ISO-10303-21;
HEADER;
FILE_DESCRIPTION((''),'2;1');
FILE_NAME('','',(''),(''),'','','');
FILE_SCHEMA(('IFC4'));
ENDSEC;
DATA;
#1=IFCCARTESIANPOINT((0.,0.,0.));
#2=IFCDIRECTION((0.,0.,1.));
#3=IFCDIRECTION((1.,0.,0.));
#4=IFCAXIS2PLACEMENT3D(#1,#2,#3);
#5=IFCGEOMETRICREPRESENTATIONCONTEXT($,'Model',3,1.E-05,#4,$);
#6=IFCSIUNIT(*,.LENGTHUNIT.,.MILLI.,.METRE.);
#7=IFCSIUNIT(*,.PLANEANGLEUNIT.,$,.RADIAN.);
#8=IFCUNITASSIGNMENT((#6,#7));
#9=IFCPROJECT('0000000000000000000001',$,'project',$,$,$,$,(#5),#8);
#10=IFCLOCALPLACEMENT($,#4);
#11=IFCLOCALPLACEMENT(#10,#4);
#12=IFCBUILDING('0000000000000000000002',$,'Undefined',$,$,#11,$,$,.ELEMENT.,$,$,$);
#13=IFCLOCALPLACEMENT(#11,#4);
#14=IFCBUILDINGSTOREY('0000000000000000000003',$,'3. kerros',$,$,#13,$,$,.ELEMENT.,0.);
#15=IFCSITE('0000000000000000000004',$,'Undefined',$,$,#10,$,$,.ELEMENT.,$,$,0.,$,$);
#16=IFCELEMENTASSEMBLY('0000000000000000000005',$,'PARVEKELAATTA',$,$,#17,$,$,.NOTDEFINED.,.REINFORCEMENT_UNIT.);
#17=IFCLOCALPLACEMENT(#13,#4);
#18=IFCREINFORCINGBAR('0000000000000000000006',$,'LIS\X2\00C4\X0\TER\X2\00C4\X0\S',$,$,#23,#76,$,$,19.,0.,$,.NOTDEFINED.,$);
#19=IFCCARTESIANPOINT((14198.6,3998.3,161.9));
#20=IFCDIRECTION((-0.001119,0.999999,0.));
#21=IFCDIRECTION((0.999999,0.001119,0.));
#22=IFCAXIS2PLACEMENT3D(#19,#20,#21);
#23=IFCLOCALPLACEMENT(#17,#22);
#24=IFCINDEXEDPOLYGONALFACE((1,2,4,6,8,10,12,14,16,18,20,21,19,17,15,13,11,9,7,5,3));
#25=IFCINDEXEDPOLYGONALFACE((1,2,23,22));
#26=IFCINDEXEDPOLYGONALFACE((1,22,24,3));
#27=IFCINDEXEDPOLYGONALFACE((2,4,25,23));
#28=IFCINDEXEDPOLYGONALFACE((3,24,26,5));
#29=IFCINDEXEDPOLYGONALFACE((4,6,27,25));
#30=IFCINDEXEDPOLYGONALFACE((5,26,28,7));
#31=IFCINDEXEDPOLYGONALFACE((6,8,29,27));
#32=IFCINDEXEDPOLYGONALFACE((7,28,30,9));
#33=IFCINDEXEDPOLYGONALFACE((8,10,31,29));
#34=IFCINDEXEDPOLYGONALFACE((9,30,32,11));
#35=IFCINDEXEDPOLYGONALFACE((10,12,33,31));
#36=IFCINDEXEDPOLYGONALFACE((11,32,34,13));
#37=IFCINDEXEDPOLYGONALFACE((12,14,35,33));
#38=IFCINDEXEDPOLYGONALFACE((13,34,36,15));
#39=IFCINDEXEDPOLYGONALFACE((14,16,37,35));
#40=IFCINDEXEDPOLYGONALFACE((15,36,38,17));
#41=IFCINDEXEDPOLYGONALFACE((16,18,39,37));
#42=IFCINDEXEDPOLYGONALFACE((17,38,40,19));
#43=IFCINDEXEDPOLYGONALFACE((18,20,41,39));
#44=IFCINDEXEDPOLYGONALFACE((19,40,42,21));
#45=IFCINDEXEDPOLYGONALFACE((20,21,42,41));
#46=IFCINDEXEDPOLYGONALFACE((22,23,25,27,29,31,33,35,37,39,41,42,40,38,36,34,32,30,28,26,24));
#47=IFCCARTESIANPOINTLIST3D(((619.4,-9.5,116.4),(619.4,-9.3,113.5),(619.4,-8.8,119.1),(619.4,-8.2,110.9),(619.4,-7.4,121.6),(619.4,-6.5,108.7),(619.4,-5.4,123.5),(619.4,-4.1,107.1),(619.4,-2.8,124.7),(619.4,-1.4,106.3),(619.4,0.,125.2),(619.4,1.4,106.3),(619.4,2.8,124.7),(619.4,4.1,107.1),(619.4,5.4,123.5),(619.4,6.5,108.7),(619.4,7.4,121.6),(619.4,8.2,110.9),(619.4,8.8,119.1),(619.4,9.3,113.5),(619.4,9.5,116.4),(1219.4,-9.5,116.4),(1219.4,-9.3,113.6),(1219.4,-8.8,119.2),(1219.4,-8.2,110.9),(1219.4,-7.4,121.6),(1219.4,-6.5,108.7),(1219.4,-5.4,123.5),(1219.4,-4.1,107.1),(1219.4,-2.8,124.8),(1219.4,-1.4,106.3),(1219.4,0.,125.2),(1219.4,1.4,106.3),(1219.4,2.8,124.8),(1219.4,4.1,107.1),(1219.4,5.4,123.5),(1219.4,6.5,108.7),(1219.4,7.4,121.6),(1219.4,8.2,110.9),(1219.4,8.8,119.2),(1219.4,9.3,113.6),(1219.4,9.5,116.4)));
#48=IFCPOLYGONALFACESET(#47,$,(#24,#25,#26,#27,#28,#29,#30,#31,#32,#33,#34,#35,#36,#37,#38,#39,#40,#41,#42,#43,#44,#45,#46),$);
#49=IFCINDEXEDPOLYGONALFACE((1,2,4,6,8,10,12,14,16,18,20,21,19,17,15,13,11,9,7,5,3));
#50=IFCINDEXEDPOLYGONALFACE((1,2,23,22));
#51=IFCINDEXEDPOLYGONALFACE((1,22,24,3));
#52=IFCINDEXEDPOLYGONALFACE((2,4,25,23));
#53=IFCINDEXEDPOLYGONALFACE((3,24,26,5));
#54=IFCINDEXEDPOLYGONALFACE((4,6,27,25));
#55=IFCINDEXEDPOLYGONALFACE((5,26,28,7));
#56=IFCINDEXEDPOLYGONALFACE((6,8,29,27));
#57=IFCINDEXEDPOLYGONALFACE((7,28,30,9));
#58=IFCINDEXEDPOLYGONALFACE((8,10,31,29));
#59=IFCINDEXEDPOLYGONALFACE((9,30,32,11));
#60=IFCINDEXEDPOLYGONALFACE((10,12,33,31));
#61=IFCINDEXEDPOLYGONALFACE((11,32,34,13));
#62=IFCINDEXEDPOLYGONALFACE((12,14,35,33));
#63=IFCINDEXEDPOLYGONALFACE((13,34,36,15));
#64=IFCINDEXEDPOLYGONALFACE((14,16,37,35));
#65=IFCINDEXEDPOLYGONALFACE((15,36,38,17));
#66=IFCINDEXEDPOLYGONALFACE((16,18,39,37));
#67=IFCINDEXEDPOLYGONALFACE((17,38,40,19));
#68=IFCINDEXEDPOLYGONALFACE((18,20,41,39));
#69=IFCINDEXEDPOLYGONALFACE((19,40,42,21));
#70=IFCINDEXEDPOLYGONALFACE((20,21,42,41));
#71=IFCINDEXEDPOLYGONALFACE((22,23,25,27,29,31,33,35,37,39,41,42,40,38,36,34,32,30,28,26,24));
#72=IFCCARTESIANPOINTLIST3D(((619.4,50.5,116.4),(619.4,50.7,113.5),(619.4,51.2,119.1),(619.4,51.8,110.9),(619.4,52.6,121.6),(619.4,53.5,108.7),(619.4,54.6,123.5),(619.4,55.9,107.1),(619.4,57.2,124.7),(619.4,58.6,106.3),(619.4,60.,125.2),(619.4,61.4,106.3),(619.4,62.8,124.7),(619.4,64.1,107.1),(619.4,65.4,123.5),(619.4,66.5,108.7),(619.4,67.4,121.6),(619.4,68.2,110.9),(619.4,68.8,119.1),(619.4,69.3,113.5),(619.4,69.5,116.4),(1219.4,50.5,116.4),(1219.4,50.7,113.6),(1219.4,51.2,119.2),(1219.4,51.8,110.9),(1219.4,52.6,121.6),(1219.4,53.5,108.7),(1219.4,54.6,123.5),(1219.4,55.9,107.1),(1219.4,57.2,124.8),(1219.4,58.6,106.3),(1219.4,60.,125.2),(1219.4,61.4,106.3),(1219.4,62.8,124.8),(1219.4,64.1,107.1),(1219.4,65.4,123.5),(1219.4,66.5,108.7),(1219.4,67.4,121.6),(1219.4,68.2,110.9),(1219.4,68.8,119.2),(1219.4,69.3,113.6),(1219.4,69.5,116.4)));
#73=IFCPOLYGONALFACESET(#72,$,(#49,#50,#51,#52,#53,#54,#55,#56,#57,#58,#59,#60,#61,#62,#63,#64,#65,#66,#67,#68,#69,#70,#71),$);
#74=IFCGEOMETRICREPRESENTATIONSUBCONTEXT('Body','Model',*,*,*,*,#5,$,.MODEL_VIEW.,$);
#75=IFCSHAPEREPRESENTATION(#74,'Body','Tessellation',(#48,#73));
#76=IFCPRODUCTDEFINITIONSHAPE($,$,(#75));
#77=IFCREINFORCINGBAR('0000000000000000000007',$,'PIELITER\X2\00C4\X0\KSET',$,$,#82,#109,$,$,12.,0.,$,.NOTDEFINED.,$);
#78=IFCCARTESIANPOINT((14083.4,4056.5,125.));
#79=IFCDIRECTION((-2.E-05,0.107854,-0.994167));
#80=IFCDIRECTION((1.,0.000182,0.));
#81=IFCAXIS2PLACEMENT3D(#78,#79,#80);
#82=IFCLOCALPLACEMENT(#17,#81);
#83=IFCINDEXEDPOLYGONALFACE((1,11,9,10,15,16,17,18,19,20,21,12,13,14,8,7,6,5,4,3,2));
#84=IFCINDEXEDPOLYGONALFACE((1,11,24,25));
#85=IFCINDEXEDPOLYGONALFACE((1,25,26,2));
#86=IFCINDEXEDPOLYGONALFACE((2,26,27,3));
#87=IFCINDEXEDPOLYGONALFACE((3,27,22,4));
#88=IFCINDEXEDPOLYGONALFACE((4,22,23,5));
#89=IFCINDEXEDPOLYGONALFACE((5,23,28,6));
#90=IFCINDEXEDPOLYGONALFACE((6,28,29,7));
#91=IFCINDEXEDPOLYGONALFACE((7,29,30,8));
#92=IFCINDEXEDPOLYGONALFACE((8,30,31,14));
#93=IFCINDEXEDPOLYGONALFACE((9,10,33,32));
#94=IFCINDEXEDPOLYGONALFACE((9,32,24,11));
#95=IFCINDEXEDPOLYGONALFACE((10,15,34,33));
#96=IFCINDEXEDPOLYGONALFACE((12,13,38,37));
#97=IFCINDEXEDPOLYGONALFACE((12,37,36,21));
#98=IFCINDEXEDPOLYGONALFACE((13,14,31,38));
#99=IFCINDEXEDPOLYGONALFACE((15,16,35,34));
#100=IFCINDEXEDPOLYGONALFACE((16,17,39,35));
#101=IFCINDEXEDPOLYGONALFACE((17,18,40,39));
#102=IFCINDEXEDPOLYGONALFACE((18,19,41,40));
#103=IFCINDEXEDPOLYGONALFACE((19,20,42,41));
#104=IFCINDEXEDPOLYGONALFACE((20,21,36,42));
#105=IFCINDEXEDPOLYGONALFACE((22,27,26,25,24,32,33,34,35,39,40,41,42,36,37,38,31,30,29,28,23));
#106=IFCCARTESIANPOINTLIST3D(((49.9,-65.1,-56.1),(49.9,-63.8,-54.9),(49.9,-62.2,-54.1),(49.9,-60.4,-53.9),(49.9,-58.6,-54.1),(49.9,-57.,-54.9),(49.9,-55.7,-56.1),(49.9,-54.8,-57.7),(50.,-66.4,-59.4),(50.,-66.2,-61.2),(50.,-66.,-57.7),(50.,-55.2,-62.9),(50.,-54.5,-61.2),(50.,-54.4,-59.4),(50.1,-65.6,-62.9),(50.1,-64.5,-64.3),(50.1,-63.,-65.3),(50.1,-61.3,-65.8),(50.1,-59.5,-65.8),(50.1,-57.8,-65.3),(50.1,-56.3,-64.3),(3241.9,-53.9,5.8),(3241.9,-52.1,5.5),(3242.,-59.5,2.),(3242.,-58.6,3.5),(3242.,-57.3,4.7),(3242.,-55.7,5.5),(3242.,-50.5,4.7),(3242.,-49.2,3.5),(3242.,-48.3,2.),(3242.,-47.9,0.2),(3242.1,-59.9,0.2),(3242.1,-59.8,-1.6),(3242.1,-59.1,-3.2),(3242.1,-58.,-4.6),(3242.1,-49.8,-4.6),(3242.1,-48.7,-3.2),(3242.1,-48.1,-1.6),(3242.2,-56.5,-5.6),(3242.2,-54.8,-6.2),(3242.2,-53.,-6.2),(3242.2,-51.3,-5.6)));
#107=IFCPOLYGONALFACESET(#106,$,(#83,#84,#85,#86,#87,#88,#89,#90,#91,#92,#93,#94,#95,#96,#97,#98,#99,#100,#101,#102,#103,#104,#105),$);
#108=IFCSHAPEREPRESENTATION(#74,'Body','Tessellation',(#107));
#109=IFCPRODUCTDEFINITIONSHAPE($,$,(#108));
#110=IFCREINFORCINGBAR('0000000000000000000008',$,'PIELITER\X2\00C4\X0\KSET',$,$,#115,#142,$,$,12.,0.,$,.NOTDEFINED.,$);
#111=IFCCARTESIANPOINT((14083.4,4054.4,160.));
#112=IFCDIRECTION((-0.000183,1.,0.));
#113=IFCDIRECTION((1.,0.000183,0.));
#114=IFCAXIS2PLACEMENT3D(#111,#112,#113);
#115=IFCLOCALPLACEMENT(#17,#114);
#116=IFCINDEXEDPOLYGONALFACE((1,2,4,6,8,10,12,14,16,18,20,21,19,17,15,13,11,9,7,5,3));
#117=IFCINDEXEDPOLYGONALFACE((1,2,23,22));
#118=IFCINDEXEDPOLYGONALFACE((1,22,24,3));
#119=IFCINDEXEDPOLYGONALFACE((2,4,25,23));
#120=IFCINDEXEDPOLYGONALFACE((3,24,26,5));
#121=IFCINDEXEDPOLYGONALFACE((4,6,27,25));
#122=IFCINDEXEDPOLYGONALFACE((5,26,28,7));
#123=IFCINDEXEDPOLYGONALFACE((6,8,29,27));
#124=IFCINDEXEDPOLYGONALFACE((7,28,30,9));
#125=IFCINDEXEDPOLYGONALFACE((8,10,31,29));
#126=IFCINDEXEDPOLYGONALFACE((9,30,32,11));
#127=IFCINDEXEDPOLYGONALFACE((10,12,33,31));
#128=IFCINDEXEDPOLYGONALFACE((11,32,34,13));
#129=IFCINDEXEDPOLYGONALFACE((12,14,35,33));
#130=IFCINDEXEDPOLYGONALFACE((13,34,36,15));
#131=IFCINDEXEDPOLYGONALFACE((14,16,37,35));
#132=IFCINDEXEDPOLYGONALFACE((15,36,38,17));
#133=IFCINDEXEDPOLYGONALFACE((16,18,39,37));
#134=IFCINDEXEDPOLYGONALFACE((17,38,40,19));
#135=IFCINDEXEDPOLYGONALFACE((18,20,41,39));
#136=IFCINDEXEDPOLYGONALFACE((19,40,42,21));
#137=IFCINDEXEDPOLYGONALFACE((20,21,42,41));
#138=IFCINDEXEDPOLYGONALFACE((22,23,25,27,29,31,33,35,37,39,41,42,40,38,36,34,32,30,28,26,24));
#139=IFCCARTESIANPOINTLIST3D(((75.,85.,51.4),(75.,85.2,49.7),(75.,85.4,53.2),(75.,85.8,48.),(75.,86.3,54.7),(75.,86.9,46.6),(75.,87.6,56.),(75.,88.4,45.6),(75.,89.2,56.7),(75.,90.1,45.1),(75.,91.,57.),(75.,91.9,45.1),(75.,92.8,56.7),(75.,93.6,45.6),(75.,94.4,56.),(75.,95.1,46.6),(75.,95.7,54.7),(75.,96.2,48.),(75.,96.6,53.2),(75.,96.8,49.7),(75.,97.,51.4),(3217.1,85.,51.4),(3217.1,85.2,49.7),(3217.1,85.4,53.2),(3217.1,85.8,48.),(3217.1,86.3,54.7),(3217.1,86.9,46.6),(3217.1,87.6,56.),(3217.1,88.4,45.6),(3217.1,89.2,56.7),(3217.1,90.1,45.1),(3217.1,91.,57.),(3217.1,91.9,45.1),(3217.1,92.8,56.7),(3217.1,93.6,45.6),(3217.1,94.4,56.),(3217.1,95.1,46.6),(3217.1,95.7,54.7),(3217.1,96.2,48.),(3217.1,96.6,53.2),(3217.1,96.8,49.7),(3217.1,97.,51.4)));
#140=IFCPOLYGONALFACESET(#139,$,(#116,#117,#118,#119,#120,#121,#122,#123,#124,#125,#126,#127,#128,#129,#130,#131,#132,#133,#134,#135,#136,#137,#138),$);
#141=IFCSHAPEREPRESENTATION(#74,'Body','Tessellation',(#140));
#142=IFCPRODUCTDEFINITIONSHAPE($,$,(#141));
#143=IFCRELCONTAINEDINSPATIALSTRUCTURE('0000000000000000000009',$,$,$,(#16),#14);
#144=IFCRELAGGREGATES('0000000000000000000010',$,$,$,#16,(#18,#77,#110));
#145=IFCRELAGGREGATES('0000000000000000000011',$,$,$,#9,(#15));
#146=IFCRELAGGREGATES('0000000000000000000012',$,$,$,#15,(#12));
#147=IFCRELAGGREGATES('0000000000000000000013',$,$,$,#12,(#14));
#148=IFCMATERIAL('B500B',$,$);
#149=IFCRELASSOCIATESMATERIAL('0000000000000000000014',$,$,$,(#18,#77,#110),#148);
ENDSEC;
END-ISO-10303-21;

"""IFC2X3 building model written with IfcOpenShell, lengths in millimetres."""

from ifc_helpers import new_model, entity, si_unit, frame, origin_with_axes, place, context, subcontext, project, spatial, source, transform, mapped, material, element, aggregate, save


model = new_model("IFC2X3")

# Units and contexts
model_context = context("Model", 3, precision=1e-05, world=origin_with_axes())
body_context = subcontext(model_context, "Body", "Model", "MODEL_VIEW")
ifc_project = project(units=[si_unit("LENGTHUNIT", "METRE", prefix="MILLI"), si_unit("PLANEANGLEUNIT", "RADIAN")], contexts=[model_context])

# Site, building, storey
site_placement = place(None, origin_with_axes())
site = spatial("IfcSite", under=ifc_project, at=site_placement, Name="Undefined", CompositionType="ELEMENT", RefElevation=0.0)
building_placement = place(site_placement, origin_with_axes())
building = spatial("IfcBuilding", under=site, at=building_placement, Name="Undefined", CompositionType="ELEMENT")
storey_placement = place(building_placement, origin_with_axes())
storey = spatial("IfcBuildingStorey", under=building, at=storey_placement, Name="3. kerros", CompositionType="ELEMENT", Elevation=0.0)

# Element assembly, reinforcing bars
assembly_1_placement = place(storey_placement, origin_with_axes())
assembly_1 = element("IfcElementAssembly", 1, at=assembly_1_placement, inside=storey, Name="PARVEKELAATTA", AssemblyPlace="NOTDEFINED", PredefinedType="REINFORCEMENT_UNIT")
ifc_material_1 = material(Name="B500B")
shared_shape_1 = source(origin_with_axes(), body_context, "Body", "AdvancedSweptSolid", [
    entity("IfcSweptDiskSolid", entity("IfcTrimmedCurve", entity("IfcLine", entity("IfcCartesianPoint", [0.0, 0.0, 0.0]), entity("IfcVector", entity("IfcDirection", [1.0, 0.0, 0.000048]), 1.0)), [entity("IfcParameterValue", 0.0)], [entity("IfcParameterValue", 600.0)], True, "PARAMETER"), 9.5, None, 0.0, 600.0),
])
shared_shape_2 = source(origin_with_axes(), body_context, "Body", "AdvancedSweptSolid", [
    entity("IfcSweptDiskSolid", entity("IfcTrimmedCurve", entity("IfcLine", entity("IfcCartesianPoint", [0.0, 0.0, 0.0]), entity("IfcVector", entity("IfcDirection", [1.0, 0.0, 0.000048]), 1.0)), [entity("IfcParameterValue", 0.0)], [entity("IfcParameterValue", 600.0)], True, "PARAMETER"), 9.5, None, 0.0, 600.0),
])
reinforcing_bar_1_placement = place(assembly_1_placement, frame((14198.6, 3998.3, 161.9), z_axis=(-0.001119, 0.999999, 0.0), x_axis=(0.999999, 0.001119, 0.0)))
reinforcing_bar_1 = element("IfcReinforcingBar", 2, at=reinforcing_bar_1_placement, material=ifc_material_1, Name="LISÄTERÄS", BarRole="NOTDEFINED", CrossSectionArea=0.0, NominalDiameter=19.0, context=body_context, shape_type="MappedRepresentation", body=[
    mapped(shared_shape_1, transform((619.4, 0.0, 115.7))),
    mapped(shared_shape_2, transform((619.4, 60.0, 115.7))),
])
shared_shape_3 = source(origin_with_axes(), body_context, "Body", "AdvancedSweptSolid", [
    entity("IfcSweptDiskSolid", entity("IfcTrimmedCurve", entity("IfcLine", entity("IfcCartesianPoint", [0.0, 0.0, 0.0]), entity("IfcVector", entity("IfcDirection", [0.999823, 0.002027, 0.018684]), 1.0)), [entity("IfcParameterValue", 0.0)], [entity("IfcParameterValue", 3192.620979)], True, "PARAMETER"), 6.0, None, 0.0, 3192.6),
])
reinforcing_bar_2_placement = place(assembly_1_placement, frame((14083.4, 4056.5, 125.0), z_axis=(-0.00002, 0.107854, -0.994167), x_axis=(1.0, 0.000182, 0.0)))
reinforcing_bar_2 = element("IfcReinforcingBar", 3, at=reinforcing_bar_2_placement, material=ifc_material_1, Name="PIELITERÄKSET", BarRole="NOTDEFINED", CrossSectionArea=0.0, NominalDiameter=12.0, context=body_context, shape_type="MappedRepresentation", body=[
    mapped(shared_shape_3, transform((50.0, -60.4, -59.9))),
])
shared_shape_4 = source(origin_with_axes(), body_context, "Body", "AdvancedSweptSolid", [
    entity("IfcSweptDiskSolid", entity("IfcTrimmedCurve", entity("IfcLine", entity("IfcCartesianPoint", [0.0, 0.0, 0.0]), entity("IfcVector", entity("IfcDirection", [1.0, 0.0, 0.0]), 1.0)), [entity("IfcParameterValue", 0.0)], [entity("IfcParameterValue", 3142.057129)], True, "PARAMETER"), 6.0, None, 0.0, 3142.1),
])
reinforcing_bar_3_placement = place(assembly_1_placement, frame((14083.4, 4054.4, 160.0), z_axis=(-0.000183, 1.0, 0.0), x_axis=(1.0, 0.000183, 0.0)))
reinforcing_bar_3 = element("IfcReinforcingBar", 4, at=reinforcing_bar_3_placement, material=ifc_material_1, Name="PIELITERÄKSET", BarRole="NOTDEFINED", CrossSectionArea=0.0, NominalDiameter=12.0, context=body_context, shape_type="MappedRepresentation", body=[
    mapped(shared_shape_4, transform((75.0, 91.0, 51.0))),
])
aggregate(assembly_1, [reinforcing_bar_1, reinforcing_bar_2, reinforcing_bar_3])

save(model, "model.ifc")
